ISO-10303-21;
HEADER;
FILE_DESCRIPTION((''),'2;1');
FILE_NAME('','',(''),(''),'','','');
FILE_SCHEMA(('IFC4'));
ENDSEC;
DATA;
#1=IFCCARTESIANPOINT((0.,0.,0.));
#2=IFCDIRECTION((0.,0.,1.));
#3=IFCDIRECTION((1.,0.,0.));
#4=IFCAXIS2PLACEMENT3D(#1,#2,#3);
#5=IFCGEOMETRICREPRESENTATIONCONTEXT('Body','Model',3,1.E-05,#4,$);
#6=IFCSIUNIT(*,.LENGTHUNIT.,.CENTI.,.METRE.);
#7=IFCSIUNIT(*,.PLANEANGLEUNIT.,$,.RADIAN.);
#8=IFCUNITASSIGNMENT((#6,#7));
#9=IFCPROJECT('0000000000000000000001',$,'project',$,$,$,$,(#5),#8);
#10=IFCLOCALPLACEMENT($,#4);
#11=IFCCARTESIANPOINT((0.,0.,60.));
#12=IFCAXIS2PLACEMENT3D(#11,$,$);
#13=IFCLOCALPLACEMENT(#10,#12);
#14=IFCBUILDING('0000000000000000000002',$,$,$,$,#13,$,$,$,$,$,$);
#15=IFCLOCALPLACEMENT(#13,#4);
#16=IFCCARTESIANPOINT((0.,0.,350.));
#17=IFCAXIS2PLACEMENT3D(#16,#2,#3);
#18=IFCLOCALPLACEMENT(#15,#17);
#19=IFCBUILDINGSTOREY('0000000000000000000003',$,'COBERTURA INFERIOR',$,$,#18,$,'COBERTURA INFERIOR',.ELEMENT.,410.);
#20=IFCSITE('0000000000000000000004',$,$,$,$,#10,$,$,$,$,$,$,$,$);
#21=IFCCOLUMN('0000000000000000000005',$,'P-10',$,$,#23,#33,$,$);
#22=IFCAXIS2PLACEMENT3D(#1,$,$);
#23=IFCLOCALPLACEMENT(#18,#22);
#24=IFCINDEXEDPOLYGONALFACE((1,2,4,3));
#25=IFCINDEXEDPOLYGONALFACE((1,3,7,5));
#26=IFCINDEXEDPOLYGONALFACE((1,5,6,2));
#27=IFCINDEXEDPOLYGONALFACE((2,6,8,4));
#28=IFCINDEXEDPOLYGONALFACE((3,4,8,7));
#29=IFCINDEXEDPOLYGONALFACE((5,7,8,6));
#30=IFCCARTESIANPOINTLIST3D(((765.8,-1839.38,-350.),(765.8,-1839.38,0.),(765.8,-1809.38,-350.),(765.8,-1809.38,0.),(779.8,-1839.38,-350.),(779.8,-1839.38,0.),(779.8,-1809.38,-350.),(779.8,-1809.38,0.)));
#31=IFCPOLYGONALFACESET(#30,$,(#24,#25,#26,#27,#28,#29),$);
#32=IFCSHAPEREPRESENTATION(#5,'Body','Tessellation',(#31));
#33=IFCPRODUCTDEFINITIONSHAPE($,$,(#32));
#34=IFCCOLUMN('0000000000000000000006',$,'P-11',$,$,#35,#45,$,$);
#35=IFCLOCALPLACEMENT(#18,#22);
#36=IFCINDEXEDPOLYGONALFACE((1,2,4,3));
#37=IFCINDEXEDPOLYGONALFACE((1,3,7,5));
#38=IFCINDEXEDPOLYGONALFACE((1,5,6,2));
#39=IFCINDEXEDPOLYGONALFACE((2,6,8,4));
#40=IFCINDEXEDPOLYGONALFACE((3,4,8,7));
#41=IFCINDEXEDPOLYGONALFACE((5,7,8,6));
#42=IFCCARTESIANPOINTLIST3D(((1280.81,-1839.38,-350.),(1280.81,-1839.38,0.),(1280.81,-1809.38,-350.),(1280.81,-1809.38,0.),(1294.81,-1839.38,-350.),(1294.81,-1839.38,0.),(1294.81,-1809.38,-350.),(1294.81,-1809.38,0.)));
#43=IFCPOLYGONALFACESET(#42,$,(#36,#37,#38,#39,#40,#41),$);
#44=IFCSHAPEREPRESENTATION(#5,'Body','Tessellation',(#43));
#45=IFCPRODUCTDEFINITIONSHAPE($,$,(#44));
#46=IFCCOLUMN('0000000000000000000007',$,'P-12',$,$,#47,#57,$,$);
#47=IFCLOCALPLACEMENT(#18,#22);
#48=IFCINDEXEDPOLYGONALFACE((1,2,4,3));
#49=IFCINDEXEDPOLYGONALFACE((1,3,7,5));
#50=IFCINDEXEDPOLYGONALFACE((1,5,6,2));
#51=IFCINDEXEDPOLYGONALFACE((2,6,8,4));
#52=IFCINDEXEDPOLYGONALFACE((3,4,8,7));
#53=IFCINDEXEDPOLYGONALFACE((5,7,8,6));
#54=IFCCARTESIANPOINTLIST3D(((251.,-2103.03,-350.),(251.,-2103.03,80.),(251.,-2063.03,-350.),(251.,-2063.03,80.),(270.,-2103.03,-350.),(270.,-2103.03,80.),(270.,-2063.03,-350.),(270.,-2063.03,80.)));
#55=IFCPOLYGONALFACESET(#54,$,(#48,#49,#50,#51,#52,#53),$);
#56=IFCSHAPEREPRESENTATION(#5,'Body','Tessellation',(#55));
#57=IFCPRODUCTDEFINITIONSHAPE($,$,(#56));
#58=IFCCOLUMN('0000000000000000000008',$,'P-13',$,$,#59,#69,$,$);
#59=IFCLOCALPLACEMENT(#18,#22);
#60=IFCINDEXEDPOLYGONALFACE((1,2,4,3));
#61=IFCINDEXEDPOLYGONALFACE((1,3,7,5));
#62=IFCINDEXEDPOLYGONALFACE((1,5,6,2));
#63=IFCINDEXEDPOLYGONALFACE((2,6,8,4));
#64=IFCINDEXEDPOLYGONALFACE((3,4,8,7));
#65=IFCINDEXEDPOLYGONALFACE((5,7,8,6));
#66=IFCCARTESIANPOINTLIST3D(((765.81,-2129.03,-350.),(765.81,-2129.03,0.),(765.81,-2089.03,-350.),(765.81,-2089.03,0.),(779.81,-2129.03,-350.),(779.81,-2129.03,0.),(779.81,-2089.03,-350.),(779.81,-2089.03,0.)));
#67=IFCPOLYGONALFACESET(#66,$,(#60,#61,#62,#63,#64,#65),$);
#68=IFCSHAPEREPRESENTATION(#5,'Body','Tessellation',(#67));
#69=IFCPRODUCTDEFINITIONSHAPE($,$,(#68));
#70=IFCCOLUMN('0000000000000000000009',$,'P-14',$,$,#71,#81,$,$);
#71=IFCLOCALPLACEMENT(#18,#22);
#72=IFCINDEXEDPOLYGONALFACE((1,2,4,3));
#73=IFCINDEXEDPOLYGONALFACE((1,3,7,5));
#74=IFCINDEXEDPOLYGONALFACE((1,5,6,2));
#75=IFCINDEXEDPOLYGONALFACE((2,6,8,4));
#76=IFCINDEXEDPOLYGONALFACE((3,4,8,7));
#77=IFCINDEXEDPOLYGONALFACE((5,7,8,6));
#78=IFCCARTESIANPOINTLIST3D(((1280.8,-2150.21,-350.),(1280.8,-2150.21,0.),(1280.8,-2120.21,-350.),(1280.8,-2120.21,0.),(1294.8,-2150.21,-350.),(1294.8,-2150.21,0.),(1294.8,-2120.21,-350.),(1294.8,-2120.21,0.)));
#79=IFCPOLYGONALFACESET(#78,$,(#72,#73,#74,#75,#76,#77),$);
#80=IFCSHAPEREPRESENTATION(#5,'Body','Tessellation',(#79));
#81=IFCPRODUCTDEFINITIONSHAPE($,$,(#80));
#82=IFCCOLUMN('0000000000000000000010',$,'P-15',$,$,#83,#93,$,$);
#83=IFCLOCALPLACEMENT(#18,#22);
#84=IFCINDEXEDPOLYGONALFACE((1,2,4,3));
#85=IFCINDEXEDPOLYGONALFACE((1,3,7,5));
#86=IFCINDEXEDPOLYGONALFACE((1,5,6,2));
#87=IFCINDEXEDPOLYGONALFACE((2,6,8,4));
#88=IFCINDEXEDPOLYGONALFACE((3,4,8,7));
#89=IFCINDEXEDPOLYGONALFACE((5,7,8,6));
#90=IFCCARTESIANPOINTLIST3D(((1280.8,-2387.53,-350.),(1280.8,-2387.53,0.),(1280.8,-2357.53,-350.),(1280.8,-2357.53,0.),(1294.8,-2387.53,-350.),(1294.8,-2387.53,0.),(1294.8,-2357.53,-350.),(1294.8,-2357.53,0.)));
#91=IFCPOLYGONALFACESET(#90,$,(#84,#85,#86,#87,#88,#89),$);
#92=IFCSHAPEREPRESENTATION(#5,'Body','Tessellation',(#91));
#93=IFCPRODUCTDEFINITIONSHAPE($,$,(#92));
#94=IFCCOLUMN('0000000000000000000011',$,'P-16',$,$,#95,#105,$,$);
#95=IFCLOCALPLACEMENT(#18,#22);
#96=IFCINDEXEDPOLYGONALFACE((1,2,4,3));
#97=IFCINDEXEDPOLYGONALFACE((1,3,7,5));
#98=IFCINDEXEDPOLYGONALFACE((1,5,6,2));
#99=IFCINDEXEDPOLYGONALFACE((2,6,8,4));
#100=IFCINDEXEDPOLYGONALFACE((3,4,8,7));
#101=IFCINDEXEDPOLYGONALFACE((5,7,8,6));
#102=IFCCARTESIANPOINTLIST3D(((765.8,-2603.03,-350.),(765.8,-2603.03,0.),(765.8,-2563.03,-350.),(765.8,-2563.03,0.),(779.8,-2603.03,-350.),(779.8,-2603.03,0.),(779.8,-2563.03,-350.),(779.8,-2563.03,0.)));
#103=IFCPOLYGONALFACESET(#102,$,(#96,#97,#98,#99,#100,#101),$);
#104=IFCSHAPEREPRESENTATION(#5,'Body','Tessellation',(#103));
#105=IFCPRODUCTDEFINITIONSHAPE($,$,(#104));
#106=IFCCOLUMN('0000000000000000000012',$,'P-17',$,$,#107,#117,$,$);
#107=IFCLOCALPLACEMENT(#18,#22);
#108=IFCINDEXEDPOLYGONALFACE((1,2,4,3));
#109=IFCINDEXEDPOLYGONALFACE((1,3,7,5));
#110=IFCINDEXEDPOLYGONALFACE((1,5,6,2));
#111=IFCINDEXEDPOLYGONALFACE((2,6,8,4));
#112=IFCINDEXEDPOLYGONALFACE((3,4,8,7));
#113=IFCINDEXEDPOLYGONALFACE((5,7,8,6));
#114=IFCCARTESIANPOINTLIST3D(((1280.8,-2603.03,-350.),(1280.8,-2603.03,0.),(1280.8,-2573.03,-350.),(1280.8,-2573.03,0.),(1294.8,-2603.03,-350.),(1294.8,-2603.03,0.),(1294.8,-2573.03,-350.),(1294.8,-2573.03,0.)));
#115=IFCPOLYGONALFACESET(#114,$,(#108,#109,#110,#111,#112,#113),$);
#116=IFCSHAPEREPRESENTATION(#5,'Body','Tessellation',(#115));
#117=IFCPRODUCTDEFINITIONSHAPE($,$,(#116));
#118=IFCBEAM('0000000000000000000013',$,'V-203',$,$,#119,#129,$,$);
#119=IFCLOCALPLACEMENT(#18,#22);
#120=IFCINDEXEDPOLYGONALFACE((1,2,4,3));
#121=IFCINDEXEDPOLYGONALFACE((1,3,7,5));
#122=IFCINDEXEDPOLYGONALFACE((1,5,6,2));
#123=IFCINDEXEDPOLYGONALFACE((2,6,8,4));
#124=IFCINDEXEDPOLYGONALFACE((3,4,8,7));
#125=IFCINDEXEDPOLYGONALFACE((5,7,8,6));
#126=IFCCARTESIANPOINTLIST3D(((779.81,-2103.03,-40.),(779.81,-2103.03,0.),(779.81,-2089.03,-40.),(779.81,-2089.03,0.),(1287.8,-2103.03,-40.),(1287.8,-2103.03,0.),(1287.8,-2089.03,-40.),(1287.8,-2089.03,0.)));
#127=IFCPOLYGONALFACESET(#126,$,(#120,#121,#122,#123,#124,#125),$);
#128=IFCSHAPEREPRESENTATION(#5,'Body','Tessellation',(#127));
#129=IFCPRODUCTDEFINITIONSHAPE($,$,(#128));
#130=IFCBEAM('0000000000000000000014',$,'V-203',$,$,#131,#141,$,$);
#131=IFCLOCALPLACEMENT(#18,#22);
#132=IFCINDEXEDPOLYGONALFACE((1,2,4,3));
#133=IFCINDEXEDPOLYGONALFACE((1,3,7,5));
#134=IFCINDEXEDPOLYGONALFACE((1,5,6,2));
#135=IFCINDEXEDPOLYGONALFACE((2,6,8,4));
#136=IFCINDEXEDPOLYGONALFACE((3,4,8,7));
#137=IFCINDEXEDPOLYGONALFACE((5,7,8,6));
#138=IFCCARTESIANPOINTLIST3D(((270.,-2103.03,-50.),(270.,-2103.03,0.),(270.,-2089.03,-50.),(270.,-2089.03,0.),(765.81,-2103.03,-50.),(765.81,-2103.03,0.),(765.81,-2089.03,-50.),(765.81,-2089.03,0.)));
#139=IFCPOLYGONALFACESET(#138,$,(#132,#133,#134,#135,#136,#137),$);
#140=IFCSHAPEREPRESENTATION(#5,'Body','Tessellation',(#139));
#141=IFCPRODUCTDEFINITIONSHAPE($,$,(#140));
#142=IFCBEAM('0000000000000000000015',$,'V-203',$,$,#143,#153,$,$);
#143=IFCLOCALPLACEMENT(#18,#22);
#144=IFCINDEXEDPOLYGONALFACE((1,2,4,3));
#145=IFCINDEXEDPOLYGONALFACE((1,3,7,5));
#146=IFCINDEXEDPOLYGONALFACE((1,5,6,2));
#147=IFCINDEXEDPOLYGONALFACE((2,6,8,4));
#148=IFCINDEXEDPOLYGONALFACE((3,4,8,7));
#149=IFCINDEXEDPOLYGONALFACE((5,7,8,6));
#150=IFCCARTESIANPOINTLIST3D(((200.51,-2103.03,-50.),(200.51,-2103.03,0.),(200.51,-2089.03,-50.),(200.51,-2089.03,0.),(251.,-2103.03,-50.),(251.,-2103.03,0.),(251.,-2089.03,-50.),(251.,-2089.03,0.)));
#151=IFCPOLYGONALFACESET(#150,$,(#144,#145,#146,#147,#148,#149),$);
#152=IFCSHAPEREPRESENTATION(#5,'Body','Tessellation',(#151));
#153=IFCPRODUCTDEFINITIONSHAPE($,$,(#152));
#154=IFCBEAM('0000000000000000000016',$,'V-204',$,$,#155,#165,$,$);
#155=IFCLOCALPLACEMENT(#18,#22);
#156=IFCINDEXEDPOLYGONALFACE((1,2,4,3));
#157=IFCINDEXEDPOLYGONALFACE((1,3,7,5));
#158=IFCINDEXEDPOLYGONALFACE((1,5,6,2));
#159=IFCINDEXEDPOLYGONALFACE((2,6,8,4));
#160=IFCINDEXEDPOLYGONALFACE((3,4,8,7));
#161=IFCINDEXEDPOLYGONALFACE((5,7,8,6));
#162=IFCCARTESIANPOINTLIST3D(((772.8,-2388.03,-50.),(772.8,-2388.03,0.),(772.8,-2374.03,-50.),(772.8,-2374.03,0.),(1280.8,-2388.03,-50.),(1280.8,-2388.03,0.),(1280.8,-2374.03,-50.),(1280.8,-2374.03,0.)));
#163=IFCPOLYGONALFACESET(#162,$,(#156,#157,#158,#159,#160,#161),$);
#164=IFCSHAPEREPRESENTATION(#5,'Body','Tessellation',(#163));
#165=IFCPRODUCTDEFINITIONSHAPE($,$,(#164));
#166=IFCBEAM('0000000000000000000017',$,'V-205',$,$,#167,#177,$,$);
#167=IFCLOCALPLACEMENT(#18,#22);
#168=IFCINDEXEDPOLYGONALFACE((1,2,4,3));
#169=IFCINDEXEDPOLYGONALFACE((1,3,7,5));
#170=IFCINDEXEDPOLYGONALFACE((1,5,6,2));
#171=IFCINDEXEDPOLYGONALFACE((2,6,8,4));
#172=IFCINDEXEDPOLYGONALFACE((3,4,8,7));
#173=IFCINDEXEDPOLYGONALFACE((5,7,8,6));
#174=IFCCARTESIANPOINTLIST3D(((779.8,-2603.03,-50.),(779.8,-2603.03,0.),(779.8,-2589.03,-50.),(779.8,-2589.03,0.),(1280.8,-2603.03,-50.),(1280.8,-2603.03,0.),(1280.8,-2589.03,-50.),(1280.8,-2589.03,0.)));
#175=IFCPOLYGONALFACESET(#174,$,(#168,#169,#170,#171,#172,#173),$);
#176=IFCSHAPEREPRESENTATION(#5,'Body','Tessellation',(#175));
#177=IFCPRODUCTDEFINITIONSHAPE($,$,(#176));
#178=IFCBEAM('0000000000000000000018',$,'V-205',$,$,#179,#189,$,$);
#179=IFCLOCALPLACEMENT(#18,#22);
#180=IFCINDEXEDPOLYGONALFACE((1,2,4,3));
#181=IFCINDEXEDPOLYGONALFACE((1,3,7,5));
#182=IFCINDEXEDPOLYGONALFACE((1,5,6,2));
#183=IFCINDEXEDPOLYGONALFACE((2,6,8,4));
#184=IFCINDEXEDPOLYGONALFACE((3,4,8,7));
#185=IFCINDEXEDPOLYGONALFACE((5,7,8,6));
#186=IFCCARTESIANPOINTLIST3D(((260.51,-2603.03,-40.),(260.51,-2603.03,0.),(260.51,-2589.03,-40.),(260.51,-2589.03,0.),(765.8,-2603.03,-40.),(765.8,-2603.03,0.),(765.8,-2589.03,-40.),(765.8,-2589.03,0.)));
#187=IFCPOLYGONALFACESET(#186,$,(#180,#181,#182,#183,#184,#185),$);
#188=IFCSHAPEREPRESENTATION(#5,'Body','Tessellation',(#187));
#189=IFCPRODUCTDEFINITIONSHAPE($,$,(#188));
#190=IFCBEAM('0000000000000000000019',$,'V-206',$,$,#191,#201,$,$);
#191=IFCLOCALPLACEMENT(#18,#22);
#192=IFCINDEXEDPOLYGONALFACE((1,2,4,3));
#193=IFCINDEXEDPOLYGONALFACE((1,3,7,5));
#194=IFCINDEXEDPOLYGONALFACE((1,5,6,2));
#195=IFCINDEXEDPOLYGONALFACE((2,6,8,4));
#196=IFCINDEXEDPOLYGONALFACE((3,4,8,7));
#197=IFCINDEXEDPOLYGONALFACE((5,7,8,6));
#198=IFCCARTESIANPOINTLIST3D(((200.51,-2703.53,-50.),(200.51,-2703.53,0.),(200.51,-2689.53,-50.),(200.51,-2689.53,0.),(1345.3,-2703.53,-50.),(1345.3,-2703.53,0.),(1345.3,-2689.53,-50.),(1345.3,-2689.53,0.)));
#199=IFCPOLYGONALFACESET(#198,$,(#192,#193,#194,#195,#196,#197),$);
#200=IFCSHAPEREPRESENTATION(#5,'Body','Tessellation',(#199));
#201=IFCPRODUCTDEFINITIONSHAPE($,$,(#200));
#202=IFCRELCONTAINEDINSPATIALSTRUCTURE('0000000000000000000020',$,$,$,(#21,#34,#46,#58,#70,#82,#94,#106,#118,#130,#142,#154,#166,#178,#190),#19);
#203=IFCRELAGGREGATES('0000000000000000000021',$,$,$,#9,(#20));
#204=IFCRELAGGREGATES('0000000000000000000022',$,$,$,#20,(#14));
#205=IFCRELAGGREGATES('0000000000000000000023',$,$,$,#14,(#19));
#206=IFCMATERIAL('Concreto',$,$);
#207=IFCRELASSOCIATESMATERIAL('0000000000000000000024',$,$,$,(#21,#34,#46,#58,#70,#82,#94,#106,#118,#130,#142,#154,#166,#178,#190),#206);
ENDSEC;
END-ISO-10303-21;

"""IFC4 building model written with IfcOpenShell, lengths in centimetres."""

from ifc_helpers import new_model, si_unit, frame, origin_with_axes, origin_2d_with_axis, place, context, project, spatial, rectangle, extrude, material, element, save


model = new_model("IFC4")

# Units and contexts
model_context = context("Model", 3, precision=1e-05, world=origin_with_axes(), identifier="Body")
ifc_project = project(units=[si_unit("LENGTHUNIT", "METRE", prefix="CENTI"), si_unit("PLANEANGLEUNIT", "RADIAN")], contexts=[model_context])

# Site, building, storey
site_placement = place(None, origin_with_axes())
site = spatial("IfcSite", under=ifc_project, at=site_placement)
building_placement = place(site_placement, frame((0.0, 0.0, 60.0)))
building = spatial("IfcBuilding", under=site, at=building_placement)
placement = place(building_placement, origin_with_axes())
storey_placement = place(placement, frame((0.0, 0.0, 350.0), z_axis=(0.0, 0.0, 1.0), x_axis=(1.0, 0.0, 0.0)))
storey = spatial("IfcBuildingStorey", under=building, at=storey_placement, Name="COBERTURA INFERIOR", LongName="COBERTURA INFERIOR", CompositionType="ELEMENT", Elevation=410.0)

# Columns
ifc_material = material(Name="Concreto")
for number, where, z_axis, x_axis, name in (
    (1, (772.8, -1824.38, 0.0), (0.0, 0.0, 1.0), (1.0, 0.0, 0.0), "P-10"),
    (2, (1287.81, -1824.38, 0.0), (0.0, 0.0, 1.0), (1.0, 0.0, 0.0), "P-11"),
):
    element("IfcColumn", number, at=place(storey_placement, frame(where, z_axis=z_axis, x_axis=x_axis)), inside=storey, material=ifc_material, Name=name, context=model_context, shape_type="SolidModel", body=[
        extrude(rectangle(XDim=14.0, YDim=30.0, at=origin_2d_with_axis()), origin_with_axes(), (0.0, 0.0, -1.0), 350.0),
    ])
column_1_placement = place(storey_placement, frame((260.5, -2083.03, 80.0), z_axis=(0.0, 0.0, 1.0), x_axis=(1.0, 0.0, 0.0)))
element("IfcColumn", 3, at=column_1_placement, inside=storey, material=ifc_material, Name="P-12", context=model_context, shape_type="SolidModel", body=[
    extrude(rectangle(XDim=19.0, YDim=40.0, at=origin_2d_with_axis()), origin_with_axes(), (0.0, 0.0, -1.0), 430.0),
])
column_2_placement = place(storey_placement, frame((772.81, -2109.03, 0.0), z_axis=(0.0, 0.0, 1.0), x_axis=(1.0, 0.0, 0.0)))
element("IfcColumn", 4, at=column_2_placement, inside=storey, material=ifc_material, Name="P-13", context=model_context, shape_type="SolidModel", body=[
    extrude(rectangle(XDim=14.0, YDim=40.0, at=origin_2d_with_axis()), origin_with_axes(), (0.0, 0.0, -1.0), 350.0),
])
for number, where, z_axis, x_axis, name in (
    (5, (1287.8, -2135.21, 0.0), (0.0, 0.0, 1.0), (1.0, 0.0, 0.0), "P-14"),
    (6, (1287.8, -2372.53, 0.0), (0.0, 0.0, 1.0), (1.0, 0.0, 0.0), "P-15"),
):
    element("IfcColumn", number, at=place(storey_placement, frame(where, z_axis=z_axis, x_axis=x_axis)), inside=storey, material=ifc_material, Name=name, context=model_context, shape_type="SolidModel", body=[
        extrude(rectangle(XDim=14.0, YDim=30.0, at=origin_2d_with_axis()), origin_with_axes(), (0.0, 0.0, -1.0), 350.0),
    ])
column_3_placement = place(storey_placement, frame((772.8, -2583.03, 0.0), z_axis=(0.0, 0.0, 1.0), x_axis=(1.0, 0.0, 0.0)))
element("IfcColumn", 7, at=column_3_placement, inside=storey, material=ifc_material, Name="P-16", context=model_context, shape_type="SolidModel", body=[
    extrude(rectangle(XDim=14.0, YDim=40.0, at=origin_2d_with_axis()), origin_with_axes(), (0.0, 0.0, -1.0), 350.0),
])
column_4_placement = place(storey_placement, frame((1287.8, -2588.03, 0.0), z_axis=(0.0, 0.0, 1.0), x_axis=(1.0, 0.0, 0.0)))
element("IfcColumn", 8, at=column_4_placement, inside=storey, material=ifc_material, Name="P-17", context=model_context, shape_type="SolidModel", body=[
    extrude(rectangle(XDim=14.0, YDim=30.0, at=origin_2d_with_axis()), origin_with_axes(), (0.0, 0.0, -1.0), 350.0),
])

# Beams
beam_1_placement = place(storey_placement, frame((1033.81, -2096.03, 0.0), z_axis=(0.0, 0.0, 1.0), x_axis=(1.0, 0.0, 0.0)))
element("IfcBeam", 9, at=beam_1_placement, inside=storey, material=ifc_material, Name="V-203", context=model_context, shape_type="SolidModel", body=[
    extrude(rectangle(XDim=14.0, YDim=40.0, at=origin_2d_with_axis()), frame((-254.0, 0.0, -20.0), z_axis=(1.0, 0.0, 0.0), x_axis=(0.0, -1.0, 0.0)), (0.0, 0.0, 1.0), 507.99),
])
beam_2_placement = place(storey_placement, frame((517.9, -2096.03, 0.0), z_axis=(0.0, 0.0, 1.0), x_axis=(1.0, 0.0, 0.0)))
element("IfcBeam", 10, at=beam_2_placement, inside=storey, material=ifc_material, Name="V-203", context=model_context, shape_type="SolidModel", body=[
    extrude(rectangle(XDim=14.0, YDim=50.0, at=origin_2d_with_axis()), frame((-247.91, 0.0, -25.0), z_axis=(1.0, 0.0, 0.0), x_axis=(0.0, -1.0, 0.0)), (0.0, 0.0, 1.0), 495.81),
])
beam_3_placement = place(storey_placement, frame((225.75, -2096.03, 0.0), z_axis=(0.0, 0.0, 1.0), x_axis=(1.0, 0.0, 0.0)))
element("IfcBeam", 11, at=beam_3_placement, inside=storey, material=ifc_material, Name="V-203", context=model_context, shape_type="SolidModel", body=[
    extrude(rectangle(XDim=14.0, YDim=50.0, at=origin_2d_with_axis()), frame((-25.25, 0.0, -25.0), z_axis=(1.0, 0.0, 0.0), x_axis=(0.0, -1.0, 0.0)), (0.0, 0.0, 1.0), 50.49),
])
beam_4_placement = place(storey_placement, frame((1026.8, -2381.03, 0.0), z_axis=(0.0, 0.0, 1.0), x_axis=(1.0, 0.0, 0.0)))
element("IfcBeam", 12, at=beam_4_placement, inside=storey, material=ifc_material, Name="V-204", context=model_context, shape_type="SolidModel", body=[
    extrude(rectangle(XDim=14.0, YDim=50.0, at=origin_2d_with_axis()), frame((-254.0, 0.0, -25.0), z_axis=(1.0, 0.0, 0.0), x_axis=(0.0, -1.0, 0.0)), (0.0, 0.0, 1.0), 508.0),
])
beam_5_placement = place(storey_placement, frame((1030.3, -2596.03, 0.0), z_axis=(0.0, 0.0, 1.0), x_axis=(1.0, 0.0, 0.0)))
element("IfcBeam", 13, at=beam_5_placement, inside=storey, material=ifc_material, Name="V-205", context=model_context, shape_type="SolidModel", body=[
    extrude(rectangle(XDim=14.0, YDim=50.0, at=origin_2d_with_axis()), frame((-250.5, 0.0, -25.0), z_axis=(1.0, 0.0, 0.0), x_axis=(0.0, -1.0, 0.0)), (0.0, 0.0, 1.0), 501.0),
])
beam_6_placement = place(storey_placement, frame((513.15, -2596.03, 0.0), z_axis=(0.0, 0.0, 1.0), x_axis=(1.0, 0.0, 0.0)))
element("IfcBeam", 14, at=beam_6_placement, inside=storey, material=ifc_material, Name="V-205", context=model_context, shape_type="SolidModel", body=[
    extrude(rectangle(XDim=14.0, YDim=40.0, at=origin_2d_with_axis()), frame((-252.65, 0.0, -20.0), z_axis=(1.0, 0.0, 0.0), x_axis=(0.0, -1.0, 0.0)), (0.0, 0.0, 1.0), 505.29),
])
beam_7_placement = place(storey_placement, frame((772.9, -2696.53, 0.0), z_axis=(0.0, 0.0, 1.0), x_axis=(1.0, 0.0, 0.0)))
element("IfcBeam", 15, at=beam_7_placement, inside=storey, material=ifc_material, Name="V-206", context=model_context, shape_type="SolidModel", body=[
    extrude(rectangle(XDim=14.0, YDim=50.0, at=origin_2d_with_axis()), frame((-572.39, 0.0, -25.0), z_axis=(1.0, 0.0, 0.0), x_axis=(0.0, -1.0, 0.0)), (0.0, 0.0, 1.0), 1144.79),
])

save(model, "model.ifc")
